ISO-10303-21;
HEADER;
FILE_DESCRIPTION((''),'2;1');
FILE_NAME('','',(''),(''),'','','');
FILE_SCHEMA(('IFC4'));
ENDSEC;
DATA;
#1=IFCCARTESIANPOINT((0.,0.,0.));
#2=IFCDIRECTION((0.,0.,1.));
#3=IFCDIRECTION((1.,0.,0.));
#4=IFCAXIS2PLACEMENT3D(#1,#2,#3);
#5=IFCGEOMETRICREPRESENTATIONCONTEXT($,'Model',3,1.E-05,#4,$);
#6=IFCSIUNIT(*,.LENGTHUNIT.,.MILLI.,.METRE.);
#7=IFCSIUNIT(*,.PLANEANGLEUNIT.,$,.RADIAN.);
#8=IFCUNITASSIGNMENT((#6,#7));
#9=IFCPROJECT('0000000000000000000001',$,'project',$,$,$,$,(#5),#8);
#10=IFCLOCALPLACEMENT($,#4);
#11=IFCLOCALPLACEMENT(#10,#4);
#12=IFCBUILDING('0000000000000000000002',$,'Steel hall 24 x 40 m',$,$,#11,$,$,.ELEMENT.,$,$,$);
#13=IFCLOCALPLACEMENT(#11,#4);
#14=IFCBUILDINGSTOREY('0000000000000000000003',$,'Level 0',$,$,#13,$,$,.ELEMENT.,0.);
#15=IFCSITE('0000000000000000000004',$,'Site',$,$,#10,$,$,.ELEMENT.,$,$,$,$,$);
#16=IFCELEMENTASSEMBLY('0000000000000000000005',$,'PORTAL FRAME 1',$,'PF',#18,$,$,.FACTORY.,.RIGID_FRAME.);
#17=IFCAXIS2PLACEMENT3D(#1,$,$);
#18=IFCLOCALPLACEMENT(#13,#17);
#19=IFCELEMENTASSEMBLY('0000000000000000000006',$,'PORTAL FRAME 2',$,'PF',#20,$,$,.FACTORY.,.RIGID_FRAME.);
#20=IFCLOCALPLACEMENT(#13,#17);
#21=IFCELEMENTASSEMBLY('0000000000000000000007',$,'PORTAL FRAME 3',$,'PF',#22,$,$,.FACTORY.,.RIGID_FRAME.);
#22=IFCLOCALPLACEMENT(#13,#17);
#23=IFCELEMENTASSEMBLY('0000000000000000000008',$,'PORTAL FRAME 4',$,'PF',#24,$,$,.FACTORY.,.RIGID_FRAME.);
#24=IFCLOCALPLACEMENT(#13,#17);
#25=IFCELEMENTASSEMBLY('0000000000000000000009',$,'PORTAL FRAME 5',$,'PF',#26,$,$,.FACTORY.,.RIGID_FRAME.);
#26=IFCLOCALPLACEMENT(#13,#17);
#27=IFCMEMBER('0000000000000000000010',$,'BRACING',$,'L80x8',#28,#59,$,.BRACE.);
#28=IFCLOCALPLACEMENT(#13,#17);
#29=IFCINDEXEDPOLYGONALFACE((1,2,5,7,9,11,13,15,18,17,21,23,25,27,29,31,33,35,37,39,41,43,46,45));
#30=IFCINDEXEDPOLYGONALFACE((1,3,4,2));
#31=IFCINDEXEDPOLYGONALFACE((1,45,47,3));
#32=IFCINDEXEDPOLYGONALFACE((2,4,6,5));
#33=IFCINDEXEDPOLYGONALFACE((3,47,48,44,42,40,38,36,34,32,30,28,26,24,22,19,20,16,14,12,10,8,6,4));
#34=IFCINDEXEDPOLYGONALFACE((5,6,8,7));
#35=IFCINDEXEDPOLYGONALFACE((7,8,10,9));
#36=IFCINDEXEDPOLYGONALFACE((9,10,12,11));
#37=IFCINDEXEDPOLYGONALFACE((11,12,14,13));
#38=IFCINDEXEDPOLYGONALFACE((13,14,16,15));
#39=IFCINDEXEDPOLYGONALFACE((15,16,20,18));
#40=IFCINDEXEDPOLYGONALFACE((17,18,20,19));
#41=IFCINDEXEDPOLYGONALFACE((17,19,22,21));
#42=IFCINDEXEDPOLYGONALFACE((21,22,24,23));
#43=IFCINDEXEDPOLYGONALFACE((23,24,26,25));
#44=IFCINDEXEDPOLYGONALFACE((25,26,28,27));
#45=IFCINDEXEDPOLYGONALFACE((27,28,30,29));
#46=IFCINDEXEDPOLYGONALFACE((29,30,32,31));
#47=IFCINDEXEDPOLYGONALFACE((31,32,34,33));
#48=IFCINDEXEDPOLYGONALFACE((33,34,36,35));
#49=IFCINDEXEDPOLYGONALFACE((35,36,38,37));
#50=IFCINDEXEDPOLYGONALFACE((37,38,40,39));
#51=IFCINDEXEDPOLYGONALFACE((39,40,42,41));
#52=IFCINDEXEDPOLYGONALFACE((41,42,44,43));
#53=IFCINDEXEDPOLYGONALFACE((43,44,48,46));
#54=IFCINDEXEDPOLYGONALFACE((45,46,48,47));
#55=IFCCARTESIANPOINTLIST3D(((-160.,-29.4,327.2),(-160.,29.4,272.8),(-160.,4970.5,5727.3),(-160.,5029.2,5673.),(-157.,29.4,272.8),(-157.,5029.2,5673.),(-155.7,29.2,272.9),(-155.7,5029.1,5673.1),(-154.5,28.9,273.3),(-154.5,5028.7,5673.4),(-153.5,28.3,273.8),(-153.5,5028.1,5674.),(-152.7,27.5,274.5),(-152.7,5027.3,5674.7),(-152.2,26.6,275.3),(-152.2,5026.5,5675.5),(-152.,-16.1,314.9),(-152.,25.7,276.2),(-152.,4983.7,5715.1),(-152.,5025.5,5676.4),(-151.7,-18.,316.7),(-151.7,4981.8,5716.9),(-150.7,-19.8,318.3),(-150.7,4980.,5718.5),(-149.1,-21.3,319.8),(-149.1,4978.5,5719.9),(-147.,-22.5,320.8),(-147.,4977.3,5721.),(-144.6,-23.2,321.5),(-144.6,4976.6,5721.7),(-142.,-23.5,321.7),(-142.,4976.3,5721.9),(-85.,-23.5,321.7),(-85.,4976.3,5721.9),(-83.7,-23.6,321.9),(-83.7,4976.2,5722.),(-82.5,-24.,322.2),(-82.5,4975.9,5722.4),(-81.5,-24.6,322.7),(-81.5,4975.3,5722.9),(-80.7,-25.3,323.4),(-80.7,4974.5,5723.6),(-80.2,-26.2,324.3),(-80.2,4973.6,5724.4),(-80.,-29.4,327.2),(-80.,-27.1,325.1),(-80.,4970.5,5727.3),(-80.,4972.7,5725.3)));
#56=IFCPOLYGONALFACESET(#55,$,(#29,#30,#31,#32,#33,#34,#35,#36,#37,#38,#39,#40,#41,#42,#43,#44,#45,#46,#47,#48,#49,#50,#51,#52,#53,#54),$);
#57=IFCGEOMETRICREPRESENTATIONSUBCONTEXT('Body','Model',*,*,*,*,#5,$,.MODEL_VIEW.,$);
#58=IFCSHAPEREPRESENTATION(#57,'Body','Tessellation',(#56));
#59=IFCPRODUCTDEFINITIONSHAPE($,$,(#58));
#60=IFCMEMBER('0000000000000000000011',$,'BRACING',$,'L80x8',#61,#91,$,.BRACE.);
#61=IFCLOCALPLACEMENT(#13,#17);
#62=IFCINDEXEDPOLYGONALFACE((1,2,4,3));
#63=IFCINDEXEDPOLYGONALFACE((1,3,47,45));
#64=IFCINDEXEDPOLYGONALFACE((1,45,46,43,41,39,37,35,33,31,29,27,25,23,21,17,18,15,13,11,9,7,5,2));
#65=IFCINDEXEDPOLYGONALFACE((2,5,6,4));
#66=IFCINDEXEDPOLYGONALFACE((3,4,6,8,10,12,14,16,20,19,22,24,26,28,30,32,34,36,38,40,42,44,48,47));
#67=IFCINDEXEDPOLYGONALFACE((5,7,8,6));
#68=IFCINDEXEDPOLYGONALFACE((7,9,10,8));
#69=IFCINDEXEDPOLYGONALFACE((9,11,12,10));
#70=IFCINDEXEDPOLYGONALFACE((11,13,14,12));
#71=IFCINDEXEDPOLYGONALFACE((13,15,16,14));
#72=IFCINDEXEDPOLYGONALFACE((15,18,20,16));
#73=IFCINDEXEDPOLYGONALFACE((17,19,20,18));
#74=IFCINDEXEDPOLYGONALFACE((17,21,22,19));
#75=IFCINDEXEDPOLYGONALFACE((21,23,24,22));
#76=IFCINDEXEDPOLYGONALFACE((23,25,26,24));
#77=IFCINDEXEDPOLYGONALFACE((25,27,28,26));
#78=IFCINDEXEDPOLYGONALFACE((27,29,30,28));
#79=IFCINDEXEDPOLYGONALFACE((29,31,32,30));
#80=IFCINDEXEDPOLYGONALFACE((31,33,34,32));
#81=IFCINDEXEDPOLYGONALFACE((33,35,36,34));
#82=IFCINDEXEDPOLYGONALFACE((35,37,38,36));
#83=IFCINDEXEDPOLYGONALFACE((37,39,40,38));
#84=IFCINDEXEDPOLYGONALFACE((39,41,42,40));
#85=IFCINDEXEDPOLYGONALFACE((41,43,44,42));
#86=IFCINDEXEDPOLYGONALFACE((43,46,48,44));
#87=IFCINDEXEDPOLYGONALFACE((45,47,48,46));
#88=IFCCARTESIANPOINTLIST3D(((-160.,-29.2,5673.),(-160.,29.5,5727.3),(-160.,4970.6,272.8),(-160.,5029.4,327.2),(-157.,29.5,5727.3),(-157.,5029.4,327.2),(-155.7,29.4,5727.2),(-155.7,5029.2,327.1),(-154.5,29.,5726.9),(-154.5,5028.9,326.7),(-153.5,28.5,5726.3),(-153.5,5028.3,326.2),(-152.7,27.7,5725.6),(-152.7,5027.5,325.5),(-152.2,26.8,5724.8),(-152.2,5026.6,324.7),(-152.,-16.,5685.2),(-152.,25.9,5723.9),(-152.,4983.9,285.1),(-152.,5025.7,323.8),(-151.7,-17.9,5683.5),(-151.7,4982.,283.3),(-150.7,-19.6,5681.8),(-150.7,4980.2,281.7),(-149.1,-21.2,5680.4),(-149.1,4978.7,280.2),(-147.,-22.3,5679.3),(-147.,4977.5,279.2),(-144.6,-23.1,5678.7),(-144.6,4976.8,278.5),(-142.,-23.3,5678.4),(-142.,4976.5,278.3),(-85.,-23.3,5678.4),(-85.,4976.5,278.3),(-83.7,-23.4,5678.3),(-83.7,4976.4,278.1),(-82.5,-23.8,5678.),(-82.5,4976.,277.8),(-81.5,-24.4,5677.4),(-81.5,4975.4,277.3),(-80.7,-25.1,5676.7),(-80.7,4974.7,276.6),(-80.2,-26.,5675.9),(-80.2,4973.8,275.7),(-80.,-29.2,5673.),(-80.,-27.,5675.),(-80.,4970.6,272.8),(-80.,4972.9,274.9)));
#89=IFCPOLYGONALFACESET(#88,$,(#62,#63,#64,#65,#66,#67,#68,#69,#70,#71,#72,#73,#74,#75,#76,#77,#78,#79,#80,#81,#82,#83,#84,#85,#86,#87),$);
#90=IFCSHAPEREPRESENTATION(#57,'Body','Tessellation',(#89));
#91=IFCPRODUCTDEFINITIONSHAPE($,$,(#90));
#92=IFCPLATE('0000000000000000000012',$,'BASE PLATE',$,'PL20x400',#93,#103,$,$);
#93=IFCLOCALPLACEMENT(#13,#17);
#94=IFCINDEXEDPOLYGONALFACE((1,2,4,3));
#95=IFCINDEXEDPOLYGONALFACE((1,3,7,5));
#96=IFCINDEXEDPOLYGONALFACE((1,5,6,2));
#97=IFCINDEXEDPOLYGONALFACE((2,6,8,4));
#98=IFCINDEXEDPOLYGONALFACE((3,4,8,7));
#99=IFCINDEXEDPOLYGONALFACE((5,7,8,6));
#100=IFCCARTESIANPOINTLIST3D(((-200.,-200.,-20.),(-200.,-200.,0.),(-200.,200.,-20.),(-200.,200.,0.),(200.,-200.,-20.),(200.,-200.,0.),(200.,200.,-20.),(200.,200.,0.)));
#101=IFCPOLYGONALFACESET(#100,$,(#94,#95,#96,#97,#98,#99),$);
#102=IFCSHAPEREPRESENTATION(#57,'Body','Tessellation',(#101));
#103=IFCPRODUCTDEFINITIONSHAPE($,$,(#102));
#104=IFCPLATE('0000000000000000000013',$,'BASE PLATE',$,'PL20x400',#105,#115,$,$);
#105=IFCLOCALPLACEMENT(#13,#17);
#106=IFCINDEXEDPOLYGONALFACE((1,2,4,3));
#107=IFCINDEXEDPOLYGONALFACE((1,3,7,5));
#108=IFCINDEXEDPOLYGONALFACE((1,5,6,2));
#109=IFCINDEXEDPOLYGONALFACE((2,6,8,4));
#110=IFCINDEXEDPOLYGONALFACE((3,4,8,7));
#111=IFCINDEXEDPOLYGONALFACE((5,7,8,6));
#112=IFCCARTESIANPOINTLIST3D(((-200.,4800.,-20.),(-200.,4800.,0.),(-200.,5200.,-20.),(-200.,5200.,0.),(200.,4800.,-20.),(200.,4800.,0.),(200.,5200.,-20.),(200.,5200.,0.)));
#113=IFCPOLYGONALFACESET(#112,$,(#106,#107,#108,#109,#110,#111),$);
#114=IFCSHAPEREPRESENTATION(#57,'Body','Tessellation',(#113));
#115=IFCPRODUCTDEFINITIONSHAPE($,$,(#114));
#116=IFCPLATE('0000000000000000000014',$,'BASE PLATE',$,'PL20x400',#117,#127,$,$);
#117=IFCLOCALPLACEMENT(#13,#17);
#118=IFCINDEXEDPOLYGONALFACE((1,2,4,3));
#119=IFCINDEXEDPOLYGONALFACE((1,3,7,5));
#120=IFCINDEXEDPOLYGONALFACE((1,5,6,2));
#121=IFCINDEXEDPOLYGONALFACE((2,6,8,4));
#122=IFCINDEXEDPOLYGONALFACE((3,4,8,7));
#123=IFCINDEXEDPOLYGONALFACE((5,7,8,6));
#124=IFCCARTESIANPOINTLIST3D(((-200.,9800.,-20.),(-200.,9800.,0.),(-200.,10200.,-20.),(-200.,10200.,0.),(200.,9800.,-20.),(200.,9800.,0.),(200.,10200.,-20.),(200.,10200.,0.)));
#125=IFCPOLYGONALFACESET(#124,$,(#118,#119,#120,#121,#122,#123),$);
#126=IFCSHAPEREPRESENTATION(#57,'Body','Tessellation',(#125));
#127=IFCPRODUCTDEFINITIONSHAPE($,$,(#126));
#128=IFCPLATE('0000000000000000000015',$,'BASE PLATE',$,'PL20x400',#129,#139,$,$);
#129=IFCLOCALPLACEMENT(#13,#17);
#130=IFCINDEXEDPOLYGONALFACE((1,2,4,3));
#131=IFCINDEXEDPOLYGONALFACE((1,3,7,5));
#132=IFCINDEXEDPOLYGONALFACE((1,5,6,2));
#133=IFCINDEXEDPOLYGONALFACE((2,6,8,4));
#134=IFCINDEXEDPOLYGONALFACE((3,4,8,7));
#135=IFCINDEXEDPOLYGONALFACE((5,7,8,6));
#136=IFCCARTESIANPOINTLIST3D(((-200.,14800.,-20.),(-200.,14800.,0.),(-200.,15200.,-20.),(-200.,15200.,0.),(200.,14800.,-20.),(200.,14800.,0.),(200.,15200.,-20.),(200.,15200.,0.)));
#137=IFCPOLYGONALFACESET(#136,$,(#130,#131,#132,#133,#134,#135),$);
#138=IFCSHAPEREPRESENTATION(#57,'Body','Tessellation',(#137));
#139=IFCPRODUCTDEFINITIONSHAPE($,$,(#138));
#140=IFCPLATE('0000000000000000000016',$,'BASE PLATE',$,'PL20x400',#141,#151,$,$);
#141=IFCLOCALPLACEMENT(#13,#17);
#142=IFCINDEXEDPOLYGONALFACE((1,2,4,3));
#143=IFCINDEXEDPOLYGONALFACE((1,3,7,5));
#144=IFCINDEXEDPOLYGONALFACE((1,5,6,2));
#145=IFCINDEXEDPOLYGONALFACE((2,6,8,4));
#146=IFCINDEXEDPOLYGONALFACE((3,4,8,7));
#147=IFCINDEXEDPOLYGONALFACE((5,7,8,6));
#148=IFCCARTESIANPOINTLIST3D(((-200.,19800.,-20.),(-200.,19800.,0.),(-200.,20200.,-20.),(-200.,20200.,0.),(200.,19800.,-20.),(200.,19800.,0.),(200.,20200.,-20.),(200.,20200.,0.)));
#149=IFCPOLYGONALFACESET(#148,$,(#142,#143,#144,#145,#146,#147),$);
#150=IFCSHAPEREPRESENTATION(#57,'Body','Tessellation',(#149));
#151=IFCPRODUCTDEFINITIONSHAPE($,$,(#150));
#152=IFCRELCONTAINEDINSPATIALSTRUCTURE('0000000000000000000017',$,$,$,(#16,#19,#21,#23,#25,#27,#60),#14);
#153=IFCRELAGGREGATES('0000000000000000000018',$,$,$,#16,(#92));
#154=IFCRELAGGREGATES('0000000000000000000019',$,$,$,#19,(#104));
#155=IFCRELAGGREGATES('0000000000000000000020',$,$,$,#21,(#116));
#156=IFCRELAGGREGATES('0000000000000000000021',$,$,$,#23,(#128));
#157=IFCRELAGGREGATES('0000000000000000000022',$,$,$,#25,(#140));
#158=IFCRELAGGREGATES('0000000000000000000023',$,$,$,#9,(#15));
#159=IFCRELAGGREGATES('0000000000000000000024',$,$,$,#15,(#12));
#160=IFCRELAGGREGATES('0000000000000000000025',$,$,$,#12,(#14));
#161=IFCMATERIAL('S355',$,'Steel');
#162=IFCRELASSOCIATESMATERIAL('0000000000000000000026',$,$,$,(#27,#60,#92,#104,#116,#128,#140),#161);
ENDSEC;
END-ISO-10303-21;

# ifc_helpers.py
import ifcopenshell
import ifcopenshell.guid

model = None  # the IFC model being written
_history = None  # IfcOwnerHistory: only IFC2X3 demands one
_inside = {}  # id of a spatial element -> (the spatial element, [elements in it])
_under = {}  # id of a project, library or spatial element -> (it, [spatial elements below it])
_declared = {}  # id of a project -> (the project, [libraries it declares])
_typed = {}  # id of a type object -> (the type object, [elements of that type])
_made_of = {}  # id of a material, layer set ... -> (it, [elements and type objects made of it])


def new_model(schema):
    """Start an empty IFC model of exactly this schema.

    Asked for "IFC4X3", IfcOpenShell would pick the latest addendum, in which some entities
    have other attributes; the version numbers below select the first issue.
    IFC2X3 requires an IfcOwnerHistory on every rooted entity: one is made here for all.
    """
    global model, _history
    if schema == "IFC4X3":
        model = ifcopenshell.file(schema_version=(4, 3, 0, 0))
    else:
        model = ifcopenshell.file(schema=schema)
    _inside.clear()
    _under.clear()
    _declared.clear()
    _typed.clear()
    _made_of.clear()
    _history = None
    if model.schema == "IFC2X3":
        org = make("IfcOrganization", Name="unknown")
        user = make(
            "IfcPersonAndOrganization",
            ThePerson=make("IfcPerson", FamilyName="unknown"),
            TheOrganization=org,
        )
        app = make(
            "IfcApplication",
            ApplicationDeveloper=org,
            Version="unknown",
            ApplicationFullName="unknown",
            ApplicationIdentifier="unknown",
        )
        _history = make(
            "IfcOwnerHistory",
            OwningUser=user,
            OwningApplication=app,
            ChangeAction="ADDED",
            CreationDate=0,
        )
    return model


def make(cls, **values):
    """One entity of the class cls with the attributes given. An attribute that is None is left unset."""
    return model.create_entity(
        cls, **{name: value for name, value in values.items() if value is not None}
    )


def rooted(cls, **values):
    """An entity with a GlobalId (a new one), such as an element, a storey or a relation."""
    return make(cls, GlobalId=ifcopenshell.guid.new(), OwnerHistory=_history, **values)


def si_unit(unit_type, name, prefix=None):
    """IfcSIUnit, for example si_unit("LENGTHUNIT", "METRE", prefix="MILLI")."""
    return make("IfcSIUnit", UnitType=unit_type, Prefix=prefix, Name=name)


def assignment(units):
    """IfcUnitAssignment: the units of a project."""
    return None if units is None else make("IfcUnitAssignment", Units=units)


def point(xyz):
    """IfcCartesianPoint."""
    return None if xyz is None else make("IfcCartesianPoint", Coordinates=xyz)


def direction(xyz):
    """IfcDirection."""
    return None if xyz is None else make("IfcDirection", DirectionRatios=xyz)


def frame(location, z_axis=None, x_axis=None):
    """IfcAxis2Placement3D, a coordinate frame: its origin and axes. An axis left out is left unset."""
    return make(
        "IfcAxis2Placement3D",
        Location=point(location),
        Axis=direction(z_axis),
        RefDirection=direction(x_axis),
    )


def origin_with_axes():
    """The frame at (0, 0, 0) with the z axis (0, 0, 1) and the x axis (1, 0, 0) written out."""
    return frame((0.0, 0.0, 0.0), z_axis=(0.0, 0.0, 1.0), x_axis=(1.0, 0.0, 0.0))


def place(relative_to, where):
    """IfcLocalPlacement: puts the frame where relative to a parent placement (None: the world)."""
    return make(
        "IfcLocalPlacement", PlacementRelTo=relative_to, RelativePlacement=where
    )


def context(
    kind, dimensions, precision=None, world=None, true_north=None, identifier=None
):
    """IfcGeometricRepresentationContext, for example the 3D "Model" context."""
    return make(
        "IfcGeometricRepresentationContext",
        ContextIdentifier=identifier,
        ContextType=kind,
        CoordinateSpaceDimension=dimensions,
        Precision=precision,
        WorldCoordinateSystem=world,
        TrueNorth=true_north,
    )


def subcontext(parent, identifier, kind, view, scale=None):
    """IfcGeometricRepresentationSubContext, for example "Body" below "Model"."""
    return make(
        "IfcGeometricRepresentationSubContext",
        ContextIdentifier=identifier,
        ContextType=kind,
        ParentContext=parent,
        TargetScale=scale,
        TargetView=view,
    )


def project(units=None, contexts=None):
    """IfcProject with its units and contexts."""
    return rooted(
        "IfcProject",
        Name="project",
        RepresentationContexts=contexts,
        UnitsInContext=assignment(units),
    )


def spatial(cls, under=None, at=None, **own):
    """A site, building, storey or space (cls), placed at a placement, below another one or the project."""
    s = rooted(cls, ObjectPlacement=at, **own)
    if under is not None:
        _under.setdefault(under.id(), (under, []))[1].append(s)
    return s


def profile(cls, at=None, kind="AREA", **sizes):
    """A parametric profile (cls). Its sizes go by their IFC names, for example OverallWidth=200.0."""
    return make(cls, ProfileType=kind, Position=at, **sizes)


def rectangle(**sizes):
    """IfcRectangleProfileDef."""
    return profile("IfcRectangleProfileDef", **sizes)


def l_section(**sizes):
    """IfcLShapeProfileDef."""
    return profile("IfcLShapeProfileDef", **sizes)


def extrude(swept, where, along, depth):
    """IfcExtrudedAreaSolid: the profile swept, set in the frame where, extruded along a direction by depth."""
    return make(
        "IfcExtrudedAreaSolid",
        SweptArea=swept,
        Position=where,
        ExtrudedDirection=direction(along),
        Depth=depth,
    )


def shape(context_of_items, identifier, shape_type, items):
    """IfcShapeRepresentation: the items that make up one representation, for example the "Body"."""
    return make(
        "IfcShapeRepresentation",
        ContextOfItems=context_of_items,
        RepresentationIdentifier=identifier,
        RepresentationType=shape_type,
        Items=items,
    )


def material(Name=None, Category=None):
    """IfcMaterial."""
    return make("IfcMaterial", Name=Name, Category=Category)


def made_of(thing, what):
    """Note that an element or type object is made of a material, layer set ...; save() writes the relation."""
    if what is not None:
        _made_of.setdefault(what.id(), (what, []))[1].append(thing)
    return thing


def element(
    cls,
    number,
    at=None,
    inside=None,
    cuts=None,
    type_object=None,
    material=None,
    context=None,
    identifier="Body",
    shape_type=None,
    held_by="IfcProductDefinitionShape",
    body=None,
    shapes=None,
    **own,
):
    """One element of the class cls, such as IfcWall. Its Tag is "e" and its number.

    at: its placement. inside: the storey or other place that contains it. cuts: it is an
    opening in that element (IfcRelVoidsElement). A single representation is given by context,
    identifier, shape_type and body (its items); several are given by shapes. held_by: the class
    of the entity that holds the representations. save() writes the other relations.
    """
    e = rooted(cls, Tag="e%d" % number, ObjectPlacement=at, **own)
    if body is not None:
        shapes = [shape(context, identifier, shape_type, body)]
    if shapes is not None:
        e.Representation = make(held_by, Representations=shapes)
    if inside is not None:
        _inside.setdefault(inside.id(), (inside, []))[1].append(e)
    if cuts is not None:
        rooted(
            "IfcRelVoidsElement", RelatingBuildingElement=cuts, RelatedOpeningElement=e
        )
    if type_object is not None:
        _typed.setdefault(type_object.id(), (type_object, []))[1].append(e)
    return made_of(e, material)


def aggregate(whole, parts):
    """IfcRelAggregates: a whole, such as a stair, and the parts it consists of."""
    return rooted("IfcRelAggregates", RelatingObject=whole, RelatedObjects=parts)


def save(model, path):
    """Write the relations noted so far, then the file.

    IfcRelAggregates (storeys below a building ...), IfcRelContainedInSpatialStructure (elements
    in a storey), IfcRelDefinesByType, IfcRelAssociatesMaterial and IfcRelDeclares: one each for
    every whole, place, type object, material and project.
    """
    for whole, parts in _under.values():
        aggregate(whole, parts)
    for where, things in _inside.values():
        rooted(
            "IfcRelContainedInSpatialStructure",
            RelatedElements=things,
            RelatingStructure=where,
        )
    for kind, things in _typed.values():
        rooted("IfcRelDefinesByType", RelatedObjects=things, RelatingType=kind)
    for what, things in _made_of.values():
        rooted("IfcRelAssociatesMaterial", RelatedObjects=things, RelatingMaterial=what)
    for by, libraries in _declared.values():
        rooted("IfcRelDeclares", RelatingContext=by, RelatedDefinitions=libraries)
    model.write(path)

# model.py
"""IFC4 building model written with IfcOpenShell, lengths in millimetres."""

from ifc_helpers import new_model, si_unit, frame, origin_with_axes, place, context, subcontext, project, spatial, rectangle, l_section, extrude, material, element, aggregate, save


model = new_model("IFC4")

# Units and contexts
model_context = context("Model", 3, precision=1e-05, world=origin_with_axes())
body_context = subcontext(model_context, "Body", "Model", "MODEL_VIEW")
ifc_project = project(units=[si_unit("LENGTHUNIT", "METRE", prefix="MILLI"), si_unit("PLANEANGLEUNIT", "RADIAN")], contexts=[model_context])

# Site, building, storey
site_placement = place(None, origin_with_axes())
site = spatial("IfcSite", under=ifc_project, at=site_placement, Name="Site", CompositionType="ELEMENT")
building_placement = place(site_placement, origin_with_axes())
building = spatial("IfcBuilding", under=site, at=building_placement, Name="Steel hall 24 x 40 m", CompositionType="ELEMENT")
storey_placement = place(building_placement, origin_with_axes())
storey = spatial("IfcBuildingStorey", under=building, at=storey_placement, Name="Level 0", CompositionType="ELEMENT", Elevation=0.0)

# Element assemblies
assembly_1_placement = place(storey_placement, origin_with_axes())
assembly_1 = element("IfcElementAssembly", 1, at=assembly_1_placement, inside=storey, Name="PORTAL FRAME 1", ObjectType="PF", AssemblyPlace="FACTORY", PredefinedType="RIGID_FRAME")
ifc_material = material(Name="S355", Category="Steel")
assembly_2_placement = place(storey_placement, frame((0.0, 5000.0, 0.0), z_axis=(0.0, 0.0, 1.0), x_axis=(1.0, 0.0, 0.0)))
assembly_2 = element("IfcElementAssembly", 2, at=assembly_2_placement, inside=storey, Name="PORTAL FRAME 2", ObjectType="PF", AssemblyPlace="FACTORY", PredefinedType="RIGID_FRAME")
assembly_3_placement = place(storey_placement, frame((0.0, 10000.0, 0.0), z_axis=(0.0, 0.0, 1.0), x_axis=(1.0, 0.0, 0.0)))
assembly_3 = element("IfcElementAssembly", 3, at=assembly_3_placement, inside=storey, Name="PORTAL FRAME 3", ObjectType="PF", AssemblyPlace="FACTORY", PredefinedType="RIGID_FRAME")
assembly_4_placement = place(storey_placement, frame((0.0, 15000.0, 0.0), z_axis=(0.0, 0.0, 1.0), x_axis=(1.0, 0.0, 0.0)))
assembly_4 = element("IfcElementAssembly", 4, at=assembly_4_placement, inside=storey, Name="PORTAL FRAME 4", ObjectType="PF", AssemblyPlace="FACTORY", PredefinedType="RIGID_FRAME")
assembly_5_placement = place(storey_placement, frame((0.0, 20000.0, 0.0), z_axis=(0.0, 0.0, 1.0), x_axis=(1.0, 0.0, 0.0)))
assembly_5 = element("IfcElementAssembly", 5, at=assembly_5_placement, inside=storey, Name="PORTAL FRAME 5", ObjectType="PF", AssemblyPlace="FACTORY", PredefinedType="RIGID_FRAME")

# Members
for number, where, z_axis, x_axis, name in (
    (6, (-120.0, 0.0, 300.0), (0.0, 0.6794, 0.7338), (1.0, 0.0, 0.0), "BRACING"),
    (7, (-120.0, 5000.0, 300.0), (0.0, -0.6794, 0.7338), (1.0, 0.0, 0.0), "BRACING"),
):
    element("IfcMember", number, at=place(storey_placement, frame(where, z_axis=z_axis, x_axis=x_axis)), inside=storey, material=ifc_material, Name=name, ObjectType="L80x8", PredefinedType="BRACE", context=body_context, shape_type="SweptSolid", body=[
        extrude(l_section(Depth=80.0, Width=80.0, Thickness=8.0, FilletRadius=10.0, EdgeRadius=5.0), origin_with_axes(), (0.0, 0.0, 1.0), 7359.3),
    ])

# Plates
plate_1_placement = place(storey_placement, frame((0.0, 0.0, -20.0), z_axis=(0.0, 0.0, 1.0), x_axis=(1.0, 0.0, 0.0)))
plate_1 = element("IfcPlate", 8, at=plate_1_placement, material=ifc_material, Name="BASE PLATE", ObjectType="PL20x400", context=body_context, shape_type="SweptSolid", body=[
    extrude(rectangle(XDim=400.0, YDim=400.0), origin_with_axes(), (0.0, 0.0, 1.0), 20.0),
])
aggregate(assembly_1, [plate_1])
plate_2_placement = place(storey_placement, frame((0.0, 5000.0, -20.0), z_axis=(0.0, 0.0, 1.0), x_axis=(1.0, 0.0, 0.0)))
plate_2 = element("IfcPlate", 9, at=plate_2_placement, material=ifc_material, Name="BASE PLATE", ObjectType="PL20x400", context=body_context, shape_type="SweptSolid", body=[
    extrude(rectangle(XDim=400.0, YDim=400.0), origin_with_axes(), (0.0, 0.0, 1.0), 20.0),
])
aggregate(assembly_2, [plate_2])
plate_3_placement = place(storey_placement, frame((0.0, 10000.0, -20.0), z_axis=(0.0, 0.0, 1.0), x_axis=(1.0, 0.0, 0.0)))
plate_3 = element("IfcPlate", 10, at=plate_3_placement, material=ifc_material, Name="BASE PLATE", ObjectType="PL20x400", context=body_context, shape_type="SweptSolid", body=[
    extrude(rectangle(XDim=400.0, YDim=400.0), origin_with_axes(), (0.0, 0.0, 1.0), 20.0),
])
aggregate(assembly_3, [plate_3])
plate_4_placement = place(storey_placement, frame((0.0, 15000.0, -20.0), z_axis=(0.0, 0.0, 1.0), x_axis=(1.0, 0.0, 0.0)))
plate_4 = element("IfcPlate", 11, at=plate_4_placement, material=ifc_material, Name="BASE PLATE", ObjectType="PL20x400", context=body_context, shape_type="SweptSolid", body=[
    extrude(rectangle(XDim=400.0, YDim=400.0), origin_with_axes(), (0.0, 0.0, 1.0), 20.0),
])
aggregate(assembly_4, [plate_4])
plate_5_placement = place(storey_placement, frame((0.0, 20000.0, -20.0), z_axis=(0.0, 0.0, 1.0), x_axis=(1.0, 0.0, 0.0)))
plate_5 = element("IfcPlate", 12, at=plate_5_placement, material=ifc_material, Name="BASE PLATE", ObjectType="PL20x400", context=body_context, shape_type="SweptSolid", body=[
    extrude(rectangle(XDim=400.0, YDim=400.0), origin_with_axes(), (0.0, 0.0, 1.0), 20.0),
])
aggregate(assembly_5, [plate_5])

save(model, "model.ifc")
